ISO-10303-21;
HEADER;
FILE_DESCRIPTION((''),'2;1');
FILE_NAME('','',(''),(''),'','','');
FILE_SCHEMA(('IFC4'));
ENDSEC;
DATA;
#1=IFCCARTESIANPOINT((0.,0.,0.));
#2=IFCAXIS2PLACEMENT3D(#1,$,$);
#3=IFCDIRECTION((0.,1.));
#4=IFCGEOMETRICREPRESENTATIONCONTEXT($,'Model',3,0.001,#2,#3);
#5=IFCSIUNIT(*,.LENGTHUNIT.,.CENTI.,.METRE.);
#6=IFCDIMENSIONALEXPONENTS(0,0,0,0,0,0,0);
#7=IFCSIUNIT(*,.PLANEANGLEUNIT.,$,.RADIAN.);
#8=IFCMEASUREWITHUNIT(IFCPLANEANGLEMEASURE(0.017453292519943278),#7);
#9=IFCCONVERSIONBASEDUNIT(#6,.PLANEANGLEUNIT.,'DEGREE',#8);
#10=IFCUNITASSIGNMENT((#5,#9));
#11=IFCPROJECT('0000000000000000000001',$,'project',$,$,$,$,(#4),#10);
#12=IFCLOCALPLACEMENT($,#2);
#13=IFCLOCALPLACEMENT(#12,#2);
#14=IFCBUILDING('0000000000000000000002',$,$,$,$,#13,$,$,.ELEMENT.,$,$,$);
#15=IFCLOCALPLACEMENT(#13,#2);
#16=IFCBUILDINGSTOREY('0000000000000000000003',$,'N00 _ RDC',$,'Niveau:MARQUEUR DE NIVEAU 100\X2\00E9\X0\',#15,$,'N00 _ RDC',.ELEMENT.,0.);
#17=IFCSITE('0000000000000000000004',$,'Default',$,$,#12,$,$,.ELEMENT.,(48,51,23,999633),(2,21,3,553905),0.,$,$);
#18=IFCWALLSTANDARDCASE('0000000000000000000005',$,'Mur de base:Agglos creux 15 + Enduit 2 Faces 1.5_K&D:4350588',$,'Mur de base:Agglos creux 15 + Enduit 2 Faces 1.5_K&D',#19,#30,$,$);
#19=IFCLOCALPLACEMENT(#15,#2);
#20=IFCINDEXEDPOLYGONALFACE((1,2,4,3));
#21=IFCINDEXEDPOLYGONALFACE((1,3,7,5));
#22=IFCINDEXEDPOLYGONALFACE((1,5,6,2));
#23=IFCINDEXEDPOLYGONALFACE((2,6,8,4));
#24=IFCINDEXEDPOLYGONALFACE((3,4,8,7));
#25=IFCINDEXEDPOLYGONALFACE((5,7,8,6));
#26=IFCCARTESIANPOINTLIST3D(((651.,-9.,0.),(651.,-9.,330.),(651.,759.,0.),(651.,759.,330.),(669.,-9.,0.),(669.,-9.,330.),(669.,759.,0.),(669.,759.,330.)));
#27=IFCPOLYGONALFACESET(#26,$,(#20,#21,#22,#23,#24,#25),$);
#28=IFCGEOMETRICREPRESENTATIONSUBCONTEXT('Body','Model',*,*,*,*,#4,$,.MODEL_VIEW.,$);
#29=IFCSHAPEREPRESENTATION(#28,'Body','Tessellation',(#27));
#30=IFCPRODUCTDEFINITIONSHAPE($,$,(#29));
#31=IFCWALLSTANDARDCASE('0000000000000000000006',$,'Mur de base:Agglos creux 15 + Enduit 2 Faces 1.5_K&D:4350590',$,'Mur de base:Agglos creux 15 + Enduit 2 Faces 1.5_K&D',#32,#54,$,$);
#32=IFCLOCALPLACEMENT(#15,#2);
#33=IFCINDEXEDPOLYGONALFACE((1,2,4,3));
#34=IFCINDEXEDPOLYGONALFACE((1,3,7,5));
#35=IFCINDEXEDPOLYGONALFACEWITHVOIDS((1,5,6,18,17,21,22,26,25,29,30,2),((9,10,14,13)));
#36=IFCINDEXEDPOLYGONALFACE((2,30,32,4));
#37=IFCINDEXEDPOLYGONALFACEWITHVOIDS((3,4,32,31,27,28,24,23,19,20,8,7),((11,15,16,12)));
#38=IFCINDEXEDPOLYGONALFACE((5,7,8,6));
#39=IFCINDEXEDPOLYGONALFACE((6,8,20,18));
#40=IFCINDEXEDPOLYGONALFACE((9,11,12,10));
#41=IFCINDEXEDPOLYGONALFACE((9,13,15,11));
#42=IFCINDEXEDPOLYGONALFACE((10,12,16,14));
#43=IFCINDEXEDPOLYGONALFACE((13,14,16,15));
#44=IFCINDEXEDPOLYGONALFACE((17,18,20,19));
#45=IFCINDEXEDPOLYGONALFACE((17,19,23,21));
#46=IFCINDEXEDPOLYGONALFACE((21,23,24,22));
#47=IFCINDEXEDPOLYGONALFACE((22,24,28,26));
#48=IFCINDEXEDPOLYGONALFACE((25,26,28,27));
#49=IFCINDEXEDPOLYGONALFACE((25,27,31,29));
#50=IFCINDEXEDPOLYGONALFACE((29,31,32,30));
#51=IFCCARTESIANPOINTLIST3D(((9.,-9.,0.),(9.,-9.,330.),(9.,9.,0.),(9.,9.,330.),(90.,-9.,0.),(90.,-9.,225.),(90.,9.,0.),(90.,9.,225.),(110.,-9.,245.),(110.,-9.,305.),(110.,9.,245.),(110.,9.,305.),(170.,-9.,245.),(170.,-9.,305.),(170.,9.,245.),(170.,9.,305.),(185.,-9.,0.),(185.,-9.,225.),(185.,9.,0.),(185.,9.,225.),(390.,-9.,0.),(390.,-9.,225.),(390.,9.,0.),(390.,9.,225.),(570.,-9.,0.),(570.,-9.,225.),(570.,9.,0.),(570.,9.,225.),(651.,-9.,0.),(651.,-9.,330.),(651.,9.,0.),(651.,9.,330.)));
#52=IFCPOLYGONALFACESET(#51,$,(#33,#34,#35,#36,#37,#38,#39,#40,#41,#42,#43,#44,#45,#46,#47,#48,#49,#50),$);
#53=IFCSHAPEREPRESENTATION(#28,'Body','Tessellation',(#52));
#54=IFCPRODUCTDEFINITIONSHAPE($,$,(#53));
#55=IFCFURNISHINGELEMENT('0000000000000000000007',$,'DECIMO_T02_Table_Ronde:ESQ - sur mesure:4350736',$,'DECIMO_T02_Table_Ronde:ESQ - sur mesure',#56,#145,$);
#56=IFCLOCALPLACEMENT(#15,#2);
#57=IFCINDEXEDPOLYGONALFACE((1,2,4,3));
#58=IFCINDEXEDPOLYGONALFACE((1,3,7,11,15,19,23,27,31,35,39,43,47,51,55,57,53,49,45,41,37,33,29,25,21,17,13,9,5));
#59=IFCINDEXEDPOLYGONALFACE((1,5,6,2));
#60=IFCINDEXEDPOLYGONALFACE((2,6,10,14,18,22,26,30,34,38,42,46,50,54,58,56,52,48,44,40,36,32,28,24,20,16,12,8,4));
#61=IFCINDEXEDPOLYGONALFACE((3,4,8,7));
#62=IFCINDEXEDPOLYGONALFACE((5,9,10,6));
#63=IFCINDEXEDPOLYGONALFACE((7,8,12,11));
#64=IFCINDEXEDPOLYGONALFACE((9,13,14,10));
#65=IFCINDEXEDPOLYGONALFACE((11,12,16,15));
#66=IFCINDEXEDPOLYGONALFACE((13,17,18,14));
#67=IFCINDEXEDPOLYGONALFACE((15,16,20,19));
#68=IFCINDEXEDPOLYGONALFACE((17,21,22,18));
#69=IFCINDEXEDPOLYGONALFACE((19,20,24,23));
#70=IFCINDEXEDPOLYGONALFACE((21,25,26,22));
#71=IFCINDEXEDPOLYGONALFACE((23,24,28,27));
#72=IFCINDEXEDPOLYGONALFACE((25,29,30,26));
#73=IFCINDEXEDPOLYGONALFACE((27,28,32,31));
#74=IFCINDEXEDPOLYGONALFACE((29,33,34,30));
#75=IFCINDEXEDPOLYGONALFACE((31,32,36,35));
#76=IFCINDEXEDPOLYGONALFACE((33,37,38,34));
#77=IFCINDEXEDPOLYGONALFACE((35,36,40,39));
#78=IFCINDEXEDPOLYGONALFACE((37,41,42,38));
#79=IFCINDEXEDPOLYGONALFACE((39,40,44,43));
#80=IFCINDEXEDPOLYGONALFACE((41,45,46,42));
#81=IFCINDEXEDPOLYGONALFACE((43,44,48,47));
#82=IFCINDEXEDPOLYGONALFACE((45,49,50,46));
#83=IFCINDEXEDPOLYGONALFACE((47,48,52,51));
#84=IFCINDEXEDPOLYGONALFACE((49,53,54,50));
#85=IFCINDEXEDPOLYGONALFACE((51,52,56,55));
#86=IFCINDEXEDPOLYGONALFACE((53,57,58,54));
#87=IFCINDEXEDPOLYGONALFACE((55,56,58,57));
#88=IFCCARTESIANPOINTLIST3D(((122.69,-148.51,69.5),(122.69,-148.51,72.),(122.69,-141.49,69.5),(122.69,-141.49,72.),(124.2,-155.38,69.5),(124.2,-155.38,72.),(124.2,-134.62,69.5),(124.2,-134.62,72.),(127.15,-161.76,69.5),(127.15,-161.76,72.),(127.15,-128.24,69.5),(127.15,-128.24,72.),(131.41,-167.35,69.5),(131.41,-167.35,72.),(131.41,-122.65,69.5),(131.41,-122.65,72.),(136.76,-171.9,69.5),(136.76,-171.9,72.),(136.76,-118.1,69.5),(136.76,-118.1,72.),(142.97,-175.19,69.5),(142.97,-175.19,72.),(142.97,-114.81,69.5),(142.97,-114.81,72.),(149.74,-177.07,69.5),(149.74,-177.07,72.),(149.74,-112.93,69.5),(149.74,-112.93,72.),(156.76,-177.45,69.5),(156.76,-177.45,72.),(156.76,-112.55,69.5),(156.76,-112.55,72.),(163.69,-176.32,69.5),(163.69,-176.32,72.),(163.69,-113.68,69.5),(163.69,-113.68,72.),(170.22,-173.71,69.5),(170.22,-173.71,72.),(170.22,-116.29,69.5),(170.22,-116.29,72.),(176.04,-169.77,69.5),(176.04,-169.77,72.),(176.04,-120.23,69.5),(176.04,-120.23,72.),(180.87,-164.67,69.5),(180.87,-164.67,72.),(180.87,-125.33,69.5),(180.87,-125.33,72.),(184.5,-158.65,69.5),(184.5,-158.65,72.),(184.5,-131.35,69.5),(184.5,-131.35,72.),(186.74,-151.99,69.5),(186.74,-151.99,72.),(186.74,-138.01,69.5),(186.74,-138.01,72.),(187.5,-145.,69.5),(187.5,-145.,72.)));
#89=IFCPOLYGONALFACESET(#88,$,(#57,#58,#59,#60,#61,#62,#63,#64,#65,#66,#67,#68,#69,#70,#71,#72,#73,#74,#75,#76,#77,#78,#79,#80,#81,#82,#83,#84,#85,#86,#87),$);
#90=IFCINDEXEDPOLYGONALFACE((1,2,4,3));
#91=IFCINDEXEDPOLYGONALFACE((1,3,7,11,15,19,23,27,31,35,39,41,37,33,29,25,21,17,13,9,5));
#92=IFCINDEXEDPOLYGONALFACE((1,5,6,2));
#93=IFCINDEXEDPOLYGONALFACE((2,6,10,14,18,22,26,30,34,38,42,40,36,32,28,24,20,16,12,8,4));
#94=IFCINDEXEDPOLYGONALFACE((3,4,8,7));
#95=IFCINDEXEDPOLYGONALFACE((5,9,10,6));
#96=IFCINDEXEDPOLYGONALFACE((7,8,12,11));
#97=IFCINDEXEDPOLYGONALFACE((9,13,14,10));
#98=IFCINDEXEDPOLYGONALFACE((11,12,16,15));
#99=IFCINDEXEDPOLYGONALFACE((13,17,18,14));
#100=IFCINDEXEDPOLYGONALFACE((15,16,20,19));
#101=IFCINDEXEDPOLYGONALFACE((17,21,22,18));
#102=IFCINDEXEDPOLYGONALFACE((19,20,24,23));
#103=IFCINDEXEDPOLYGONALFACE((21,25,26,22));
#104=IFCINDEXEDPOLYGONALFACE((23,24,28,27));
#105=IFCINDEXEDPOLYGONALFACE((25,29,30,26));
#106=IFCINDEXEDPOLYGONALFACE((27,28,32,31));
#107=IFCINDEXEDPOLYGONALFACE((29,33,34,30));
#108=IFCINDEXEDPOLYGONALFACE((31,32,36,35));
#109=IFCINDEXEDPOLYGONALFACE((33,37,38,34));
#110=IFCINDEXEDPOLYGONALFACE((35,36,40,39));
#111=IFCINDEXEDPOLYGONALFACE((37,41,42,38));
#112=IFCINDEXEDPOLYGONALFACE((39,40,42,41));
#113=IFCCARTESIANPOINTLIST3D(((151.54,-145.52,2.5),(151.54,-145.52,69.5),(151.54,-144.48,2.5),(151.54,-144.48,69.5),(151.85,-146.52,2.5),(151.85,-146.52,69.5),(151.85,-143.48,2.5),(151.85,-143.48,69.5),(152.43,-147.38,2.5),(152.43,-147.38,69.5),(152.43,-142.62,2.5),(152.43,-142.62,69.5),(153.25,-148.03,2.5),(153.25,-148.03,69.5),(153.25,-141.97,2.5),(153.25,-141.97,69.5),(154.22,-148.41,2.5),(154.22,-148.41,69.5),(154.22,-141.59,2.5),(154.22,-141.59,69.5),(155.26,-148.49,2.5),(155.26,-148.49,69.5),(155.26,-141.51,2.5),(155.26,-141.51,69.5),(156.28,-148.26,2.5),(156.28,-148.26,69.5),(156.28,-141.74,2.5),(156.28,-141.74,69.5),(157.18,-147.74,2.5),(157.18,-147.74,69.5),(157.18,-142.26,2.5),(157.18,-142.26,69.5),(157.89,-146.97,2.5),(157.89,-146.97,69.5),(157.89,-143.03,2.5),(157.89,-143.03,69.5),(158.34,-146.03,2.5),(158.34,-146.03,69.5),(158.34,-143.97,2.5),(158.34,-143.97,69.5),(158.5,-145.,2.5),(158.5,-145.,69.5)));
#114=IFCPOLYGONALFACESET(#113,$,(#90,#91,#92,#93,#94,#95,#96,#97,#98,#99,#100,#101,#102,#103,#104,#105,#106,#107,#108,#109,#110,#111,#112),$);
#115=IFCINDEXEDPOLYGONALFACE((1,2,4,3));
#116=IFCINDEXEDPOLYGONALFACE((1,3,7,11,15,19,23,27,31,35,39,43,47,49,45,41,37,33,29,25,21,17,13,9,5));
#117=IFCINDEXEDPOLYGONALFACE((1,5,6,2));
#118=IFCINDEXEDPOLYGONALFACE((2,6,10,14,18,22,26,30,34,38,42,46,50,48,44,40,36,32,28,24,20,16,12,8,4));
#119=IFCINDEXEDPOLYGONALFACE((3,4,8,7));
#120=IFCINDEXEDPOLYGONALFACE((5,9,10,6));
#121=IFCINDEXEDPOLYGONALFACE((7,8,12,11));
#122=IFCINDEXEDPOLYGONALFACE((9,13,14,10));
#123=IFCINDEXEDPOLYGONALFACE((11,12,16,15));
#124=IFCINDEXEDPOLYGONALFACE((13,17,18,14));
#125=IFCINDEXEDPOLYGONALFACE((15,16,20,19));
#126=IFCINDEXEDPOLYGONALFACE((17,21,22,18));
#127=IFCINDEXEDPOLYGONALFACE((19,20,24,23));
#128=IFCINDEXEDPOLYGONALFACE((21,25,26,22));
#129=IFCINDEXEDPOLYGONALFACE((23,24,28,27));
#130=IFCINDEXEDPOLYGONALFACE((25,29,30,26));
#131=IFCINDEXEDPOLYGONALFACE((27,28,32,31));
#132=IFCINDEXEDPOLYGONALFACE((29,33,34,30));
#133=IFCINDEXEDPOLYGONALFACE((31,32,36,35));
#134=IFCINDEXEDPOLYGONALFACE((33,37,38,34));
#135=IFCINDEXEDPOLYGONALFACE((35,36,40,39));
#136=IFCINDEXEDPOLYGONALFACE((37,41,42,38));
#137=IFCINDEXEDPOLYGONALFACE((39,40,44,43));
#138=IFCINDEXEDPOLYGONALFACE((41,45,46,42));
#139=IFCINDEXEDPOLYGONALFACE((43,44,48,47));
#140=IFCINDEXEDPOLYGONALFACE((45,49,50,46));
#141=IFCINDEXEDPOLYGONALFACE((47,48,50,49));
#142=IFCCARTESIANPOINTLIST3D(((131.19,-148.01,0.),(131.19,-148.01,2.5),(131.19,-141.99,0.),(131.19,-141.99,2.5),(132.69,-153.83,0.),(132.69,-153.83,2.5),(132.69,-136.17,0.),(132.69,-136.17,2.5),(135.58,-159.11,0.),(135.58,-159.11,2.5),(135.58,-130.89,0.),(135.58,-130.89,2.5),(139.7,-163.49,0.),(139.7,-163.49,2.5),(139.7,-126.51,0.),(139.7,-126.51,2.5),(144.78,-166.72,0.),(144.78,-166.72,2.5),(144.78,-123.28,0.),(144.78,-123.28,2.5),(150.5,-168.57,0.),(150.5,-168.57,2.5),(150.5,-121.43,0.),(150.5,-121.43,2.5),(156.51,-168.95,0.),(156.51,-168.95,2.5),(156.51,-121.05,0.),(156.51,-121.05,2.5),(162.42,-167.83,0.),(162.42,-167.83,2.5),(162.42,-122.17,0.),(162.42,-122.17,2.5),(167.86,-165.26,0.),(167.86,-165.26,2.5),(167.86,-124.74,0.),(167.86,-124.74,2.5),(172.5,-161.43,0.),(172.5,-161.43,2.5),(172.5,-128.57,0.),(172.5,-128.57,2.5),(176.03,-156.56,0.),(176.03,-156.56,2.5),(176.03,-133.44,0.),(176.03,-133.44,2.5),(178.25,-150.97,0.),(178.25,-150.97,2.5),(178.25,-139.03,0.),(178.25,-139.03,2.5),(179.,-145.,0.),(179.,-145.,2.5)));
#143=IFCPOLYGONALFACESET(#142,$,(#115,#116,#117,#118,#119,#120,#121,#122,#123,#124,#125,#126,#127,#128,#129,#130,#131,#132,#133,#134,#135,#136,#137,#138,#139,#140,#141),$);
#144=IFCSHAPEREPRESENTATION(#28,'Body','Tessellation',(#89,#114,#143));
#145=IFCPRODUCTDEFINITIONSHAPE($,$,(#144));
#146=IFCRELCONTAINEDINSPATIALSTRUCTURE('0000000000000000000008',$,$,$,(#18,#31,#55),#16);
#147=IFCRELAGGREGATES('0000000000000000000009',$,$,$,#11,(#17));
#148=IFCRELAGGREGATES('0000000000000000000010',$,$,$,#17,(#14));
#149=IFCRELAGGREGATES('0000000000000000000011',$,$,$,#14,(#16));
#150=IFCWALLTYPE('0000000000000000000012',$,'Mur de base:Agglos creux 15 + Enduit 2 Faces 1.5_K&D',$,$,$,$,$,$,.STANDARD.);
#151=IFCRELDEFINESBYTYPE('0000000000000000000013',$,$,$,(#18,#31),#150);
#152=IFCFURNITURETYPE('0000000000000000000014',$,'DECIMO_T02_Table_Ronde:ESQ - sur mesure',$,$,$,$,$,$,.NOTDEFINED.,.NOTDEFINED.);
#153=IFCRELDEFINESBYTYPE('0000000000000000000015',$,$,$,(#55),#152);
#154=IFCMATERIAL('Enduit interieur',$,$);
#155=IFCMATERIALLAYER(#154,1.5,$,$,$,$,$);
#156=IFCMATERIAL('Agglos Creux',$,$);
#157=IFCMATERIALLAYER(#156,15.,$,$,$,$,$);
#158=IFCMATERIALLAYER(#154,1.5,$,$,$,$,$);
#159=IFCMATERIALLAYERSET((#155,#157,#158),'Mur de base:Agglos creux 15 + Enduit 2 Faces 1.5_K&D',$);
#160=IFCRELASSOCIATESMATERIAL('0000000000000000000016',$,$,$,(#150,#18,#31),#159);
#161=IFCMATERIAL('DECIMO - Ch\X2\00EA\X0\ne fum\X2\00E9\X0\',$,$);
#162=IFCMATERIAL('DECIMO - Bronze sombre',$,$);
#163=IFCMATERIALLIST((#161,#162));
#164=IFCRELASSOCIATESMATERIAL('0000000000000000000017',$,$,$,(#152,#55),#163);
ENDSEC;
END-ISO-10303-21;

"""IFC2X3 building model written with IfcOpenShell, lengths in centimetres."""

from ifc_helpers import new_model, entity, si_unit, converted_unit, direction, frame, frame_2d, origin, origin_2d_with_axis, place, context, subcontext, project, spatial, rectangle, circle, extrude, source, transform, mapped, material, material_list, layer, layer_set, layer_usage, type_object, type_shapes, element, save


model = new_model("IFC2X3")

# Units and contexts
model_context = context("Model", 3, precision=0.001, world=origin(), true_north=direction((0.0, 1.0)))
body_context = subcontext(model_context, "Body", "Model", "MODEL_VIEW")
ifc_project = project(units=[si_unit("LENGTHUNIT", "METRE", prefix="CENTI"), converted_unit("PLANEANGLEUNIT", "DEGREE", entity("IfcPlaneAngleMeasure", 0.017453292519943278), si_unit("PLANEANGLEUNIT", "RADIAN"), dimensions=[0, 0, 0, 0, 0, 0, 0])], contexts=[model_context])

# Site, building, storey
site_placement = place(None, origin())
site = spatial("IfcSite", under=ifc_project, at=site_placement, Name="Default", CompositionType="ELEMENT", RefLatitude=(48, 51, 23, 999633), RefLongitude=(2, 21, 3, 553905), RefElevation=0.0)
building_placement = place(site_placement, origin())
building = spatial("IfcBuilding", under=site, at=building_placement, CompositionType="ELEMENT")
storey_placement = place(building_placement, origin())
storey = spatial("IfcBuildingStorey", under=building, at=storey_placement, Name="N00 _ RDC", ObjectType="Niveau:MARQUEUR DE NIVEAU 100é", LongName="N00 _ RDC", CompositionType="ELEMENT", Elevation=0.0)

# Wall
ifc_material_1 = material(Name="Enduit interieur")
ifc_layer_1 = layer(ifc_material_1, 1.5)
ifc_material_2 = material(Name="Agglos Creux")
ifc_layer_2 = layer(ifc_material_2, 15.0)
ifc_layer_3 = layer(ifc_material_1, 1.5)
ifc_layer_set = layer_set([ifc_layer_1, ifc_layer_2, ifc_layer_3], Name="Mur de base:Agglos creux 15 + Enduit 2 Faces 1.5_K&D")
ifc_layer_usage_1 = layer_usage(ifc_layer_set, "AXIS2", "NEGATIVE", 9.0)
wall_type = type_object("IfcWallType", Name="Mur de base:Agglos creux 15 + Enduit 2 Faces 1.5_K&D", PredefinedType="STANDARD", material=ifc_layer_set)
wall_1_placement = place(storey_placement, frame((660.0, -9.0, 0.0), z_axis=(0.0, 0.0, 1.0), x_axis=(0.0, 1.0, 0.0)))
element("IfcWallStandardCase", 1, at=wall_1_placement, inside=storey, type_object=wall_type, material=ifc_layer_usage_1, Name="Mur de base:Agglos creux 15 + Enduit 2 Faces 1.5_K&D:4350588", ObjectType="Mur de base:Agglos creux 15 + Enduit 2 Faces 1.5_K&D", context=body_context, shape_type="SweptSolid", body=[
    extrude(rectangle(XDim=768.0, YDim=18.0, at=frame_2d((384.0, 0.0), x_axis=(-1.0, 0.0))), origin(), (0.0, 0.0, 1.0), 330.0),
])

# Wall, openings
ifc_layer_usage_2 = layer_usage(ifc_layer_set, "AXIS2", "NEGATIVE", 9.0)
wall_2_placement = place(storey_placement, frame((9.0, 0.0, 0.0)))
wall_2 = element("IfcWallStandardCase", 2, at=wall_2_placement, inside=storey, type_object=wall_type, material=ifc_layer_usage_2, Name="Mur de base:Agglos creux 15 + Enduit 2 Faces 1.5_K&D:4350590", ObjectType="Mur de base:Agglos creux 15 + Enduit 2 Faces 1.5_K&D", context=body_context, shape_type="SweptSolid", body=[
    extrude(rectangle(XDim=642.0, YDim=18.0, at=frame_2d((321.0, 0.0), x_axis=(1.0, 0.0))), origin(), (0.0, 0.0, 1.0), 330.0),
])
opening_1_placement = place(wall_2_placement, origin())
element("IfcOpeningElement", 3, at=opening_1_placement, cuts=wall_2, ObjectType="Opening", context=body_context, shape_type="SweptSolid", body=[
    extrude(rectangle(XDim=225.0, YDim=95.0, at=origin_2d_with_axis()), frame((128.5, -9.0, 112.5), z_axis=(0.0, 1.0, 0.0), x_axis=(0.0, 0.0, -1.0)), (0.0, 0.0, 1.0), 18.0),
])
opening_2_placement = place(wall_2_placement, origin())
element("IfcOpeningElement", 4, at=opening_2_placement, cuts=wall_2, ObjectType="Opening", context=body_context, shape_type="SweptSolid", body=[
    extrude(rectangle(XDim=225.0, YDim=180.0, at=frame_2d((0.0, 0.0), x_axis=(1.0, 0.0))), frame((471.0, -9.0, 112.5), z_axis=(0.0, 1.0, 0.0), x_axis=(0.0, 0.0, -1.0)), (0.0, 0.0, 1.0), 18.0),
])
opening_3_placement = place(wall_2_placement, origin())
element("IfcOpeningElement", 5, at=opening_3_placement, cuts=wall_2, ObjectType="Opening", context=body_context, shape_type="SweptSolid", body=[
    extrude(rectangle(XDim=60.0, YDim=60.0, at=frame_2d((0.0, 0.0), x_axis=(1.0, 0.0))), frame((131.0, -9.0, 275.0), z_axis=(0.0, 1.0, 0.0), x_axis=(0.0, 0.0, -1.0)), (0.0, 0.0, 1.0), 18.0),
])

# Furnishing element
ifc_material_3 = material(Name="DECIMO - Chêne fumé")
ifc_material_4 = material(Name="DECIMO - Bronze sombre")
ifc_material_list_1 = material_list([ifc_material_3, ifc_material_4])
furniture_type_1 = type_object("IfcFurnitureType", Name="DECIMO_T02_Table_Ronde:ESQ - sur mesure", AssemblyPlace="NOTDEFINED", material=ifc_material_list_1)
shared_shape_1 = source(origin(), body_context, "Body", "SweptSolid", [
    extrude(circle(Radius=32.5, at=frame_2d((0.0, 0.0), x_axis=(1.0, 0.0))), frame((0.0, 0.0, 69.5)), (0.0, 0.0, 1.0), 2.5),
    extrude(circle(Radius=3.5, at=frame_2d((0.0, 0.0), x_axis=(1.0, 0.0))), frame((0.0, 0.0, 2.5)), (0.0, 0.0, 1.0), 67.0),
    extrude(circle(Radius=24.0, at=frame_2d((0.0, 0.0), x_axis=(1.0, 0.0))), origin(), (0.0, 0.0, 1.0), 2.5),
])
type_shapes(furniture_type_1, [shared_shape_1])
for number, where, name in (
    (6, (155.0, -145.0, 0.0), "DECIMO_T02_Table_Ronde:ESQ - sur mesure:4350736"),
):
    element("IfcFurnishingElement", number, at=place(storey_placement, frame(where)), inside=storey, type_object=furniture_type_1, material=ifc_material_list_1, Name=name, ObjectType="DECIMO_T02_Table_Ronde:ESQ - sur mesure", context=body_context, shape_type="MappedRepresentation", body=[
        mapped(shared_shape_1, transform((0.0, 0.0, 0.0), scale=1.0)),
    ])

save(model, "model.ifc")
